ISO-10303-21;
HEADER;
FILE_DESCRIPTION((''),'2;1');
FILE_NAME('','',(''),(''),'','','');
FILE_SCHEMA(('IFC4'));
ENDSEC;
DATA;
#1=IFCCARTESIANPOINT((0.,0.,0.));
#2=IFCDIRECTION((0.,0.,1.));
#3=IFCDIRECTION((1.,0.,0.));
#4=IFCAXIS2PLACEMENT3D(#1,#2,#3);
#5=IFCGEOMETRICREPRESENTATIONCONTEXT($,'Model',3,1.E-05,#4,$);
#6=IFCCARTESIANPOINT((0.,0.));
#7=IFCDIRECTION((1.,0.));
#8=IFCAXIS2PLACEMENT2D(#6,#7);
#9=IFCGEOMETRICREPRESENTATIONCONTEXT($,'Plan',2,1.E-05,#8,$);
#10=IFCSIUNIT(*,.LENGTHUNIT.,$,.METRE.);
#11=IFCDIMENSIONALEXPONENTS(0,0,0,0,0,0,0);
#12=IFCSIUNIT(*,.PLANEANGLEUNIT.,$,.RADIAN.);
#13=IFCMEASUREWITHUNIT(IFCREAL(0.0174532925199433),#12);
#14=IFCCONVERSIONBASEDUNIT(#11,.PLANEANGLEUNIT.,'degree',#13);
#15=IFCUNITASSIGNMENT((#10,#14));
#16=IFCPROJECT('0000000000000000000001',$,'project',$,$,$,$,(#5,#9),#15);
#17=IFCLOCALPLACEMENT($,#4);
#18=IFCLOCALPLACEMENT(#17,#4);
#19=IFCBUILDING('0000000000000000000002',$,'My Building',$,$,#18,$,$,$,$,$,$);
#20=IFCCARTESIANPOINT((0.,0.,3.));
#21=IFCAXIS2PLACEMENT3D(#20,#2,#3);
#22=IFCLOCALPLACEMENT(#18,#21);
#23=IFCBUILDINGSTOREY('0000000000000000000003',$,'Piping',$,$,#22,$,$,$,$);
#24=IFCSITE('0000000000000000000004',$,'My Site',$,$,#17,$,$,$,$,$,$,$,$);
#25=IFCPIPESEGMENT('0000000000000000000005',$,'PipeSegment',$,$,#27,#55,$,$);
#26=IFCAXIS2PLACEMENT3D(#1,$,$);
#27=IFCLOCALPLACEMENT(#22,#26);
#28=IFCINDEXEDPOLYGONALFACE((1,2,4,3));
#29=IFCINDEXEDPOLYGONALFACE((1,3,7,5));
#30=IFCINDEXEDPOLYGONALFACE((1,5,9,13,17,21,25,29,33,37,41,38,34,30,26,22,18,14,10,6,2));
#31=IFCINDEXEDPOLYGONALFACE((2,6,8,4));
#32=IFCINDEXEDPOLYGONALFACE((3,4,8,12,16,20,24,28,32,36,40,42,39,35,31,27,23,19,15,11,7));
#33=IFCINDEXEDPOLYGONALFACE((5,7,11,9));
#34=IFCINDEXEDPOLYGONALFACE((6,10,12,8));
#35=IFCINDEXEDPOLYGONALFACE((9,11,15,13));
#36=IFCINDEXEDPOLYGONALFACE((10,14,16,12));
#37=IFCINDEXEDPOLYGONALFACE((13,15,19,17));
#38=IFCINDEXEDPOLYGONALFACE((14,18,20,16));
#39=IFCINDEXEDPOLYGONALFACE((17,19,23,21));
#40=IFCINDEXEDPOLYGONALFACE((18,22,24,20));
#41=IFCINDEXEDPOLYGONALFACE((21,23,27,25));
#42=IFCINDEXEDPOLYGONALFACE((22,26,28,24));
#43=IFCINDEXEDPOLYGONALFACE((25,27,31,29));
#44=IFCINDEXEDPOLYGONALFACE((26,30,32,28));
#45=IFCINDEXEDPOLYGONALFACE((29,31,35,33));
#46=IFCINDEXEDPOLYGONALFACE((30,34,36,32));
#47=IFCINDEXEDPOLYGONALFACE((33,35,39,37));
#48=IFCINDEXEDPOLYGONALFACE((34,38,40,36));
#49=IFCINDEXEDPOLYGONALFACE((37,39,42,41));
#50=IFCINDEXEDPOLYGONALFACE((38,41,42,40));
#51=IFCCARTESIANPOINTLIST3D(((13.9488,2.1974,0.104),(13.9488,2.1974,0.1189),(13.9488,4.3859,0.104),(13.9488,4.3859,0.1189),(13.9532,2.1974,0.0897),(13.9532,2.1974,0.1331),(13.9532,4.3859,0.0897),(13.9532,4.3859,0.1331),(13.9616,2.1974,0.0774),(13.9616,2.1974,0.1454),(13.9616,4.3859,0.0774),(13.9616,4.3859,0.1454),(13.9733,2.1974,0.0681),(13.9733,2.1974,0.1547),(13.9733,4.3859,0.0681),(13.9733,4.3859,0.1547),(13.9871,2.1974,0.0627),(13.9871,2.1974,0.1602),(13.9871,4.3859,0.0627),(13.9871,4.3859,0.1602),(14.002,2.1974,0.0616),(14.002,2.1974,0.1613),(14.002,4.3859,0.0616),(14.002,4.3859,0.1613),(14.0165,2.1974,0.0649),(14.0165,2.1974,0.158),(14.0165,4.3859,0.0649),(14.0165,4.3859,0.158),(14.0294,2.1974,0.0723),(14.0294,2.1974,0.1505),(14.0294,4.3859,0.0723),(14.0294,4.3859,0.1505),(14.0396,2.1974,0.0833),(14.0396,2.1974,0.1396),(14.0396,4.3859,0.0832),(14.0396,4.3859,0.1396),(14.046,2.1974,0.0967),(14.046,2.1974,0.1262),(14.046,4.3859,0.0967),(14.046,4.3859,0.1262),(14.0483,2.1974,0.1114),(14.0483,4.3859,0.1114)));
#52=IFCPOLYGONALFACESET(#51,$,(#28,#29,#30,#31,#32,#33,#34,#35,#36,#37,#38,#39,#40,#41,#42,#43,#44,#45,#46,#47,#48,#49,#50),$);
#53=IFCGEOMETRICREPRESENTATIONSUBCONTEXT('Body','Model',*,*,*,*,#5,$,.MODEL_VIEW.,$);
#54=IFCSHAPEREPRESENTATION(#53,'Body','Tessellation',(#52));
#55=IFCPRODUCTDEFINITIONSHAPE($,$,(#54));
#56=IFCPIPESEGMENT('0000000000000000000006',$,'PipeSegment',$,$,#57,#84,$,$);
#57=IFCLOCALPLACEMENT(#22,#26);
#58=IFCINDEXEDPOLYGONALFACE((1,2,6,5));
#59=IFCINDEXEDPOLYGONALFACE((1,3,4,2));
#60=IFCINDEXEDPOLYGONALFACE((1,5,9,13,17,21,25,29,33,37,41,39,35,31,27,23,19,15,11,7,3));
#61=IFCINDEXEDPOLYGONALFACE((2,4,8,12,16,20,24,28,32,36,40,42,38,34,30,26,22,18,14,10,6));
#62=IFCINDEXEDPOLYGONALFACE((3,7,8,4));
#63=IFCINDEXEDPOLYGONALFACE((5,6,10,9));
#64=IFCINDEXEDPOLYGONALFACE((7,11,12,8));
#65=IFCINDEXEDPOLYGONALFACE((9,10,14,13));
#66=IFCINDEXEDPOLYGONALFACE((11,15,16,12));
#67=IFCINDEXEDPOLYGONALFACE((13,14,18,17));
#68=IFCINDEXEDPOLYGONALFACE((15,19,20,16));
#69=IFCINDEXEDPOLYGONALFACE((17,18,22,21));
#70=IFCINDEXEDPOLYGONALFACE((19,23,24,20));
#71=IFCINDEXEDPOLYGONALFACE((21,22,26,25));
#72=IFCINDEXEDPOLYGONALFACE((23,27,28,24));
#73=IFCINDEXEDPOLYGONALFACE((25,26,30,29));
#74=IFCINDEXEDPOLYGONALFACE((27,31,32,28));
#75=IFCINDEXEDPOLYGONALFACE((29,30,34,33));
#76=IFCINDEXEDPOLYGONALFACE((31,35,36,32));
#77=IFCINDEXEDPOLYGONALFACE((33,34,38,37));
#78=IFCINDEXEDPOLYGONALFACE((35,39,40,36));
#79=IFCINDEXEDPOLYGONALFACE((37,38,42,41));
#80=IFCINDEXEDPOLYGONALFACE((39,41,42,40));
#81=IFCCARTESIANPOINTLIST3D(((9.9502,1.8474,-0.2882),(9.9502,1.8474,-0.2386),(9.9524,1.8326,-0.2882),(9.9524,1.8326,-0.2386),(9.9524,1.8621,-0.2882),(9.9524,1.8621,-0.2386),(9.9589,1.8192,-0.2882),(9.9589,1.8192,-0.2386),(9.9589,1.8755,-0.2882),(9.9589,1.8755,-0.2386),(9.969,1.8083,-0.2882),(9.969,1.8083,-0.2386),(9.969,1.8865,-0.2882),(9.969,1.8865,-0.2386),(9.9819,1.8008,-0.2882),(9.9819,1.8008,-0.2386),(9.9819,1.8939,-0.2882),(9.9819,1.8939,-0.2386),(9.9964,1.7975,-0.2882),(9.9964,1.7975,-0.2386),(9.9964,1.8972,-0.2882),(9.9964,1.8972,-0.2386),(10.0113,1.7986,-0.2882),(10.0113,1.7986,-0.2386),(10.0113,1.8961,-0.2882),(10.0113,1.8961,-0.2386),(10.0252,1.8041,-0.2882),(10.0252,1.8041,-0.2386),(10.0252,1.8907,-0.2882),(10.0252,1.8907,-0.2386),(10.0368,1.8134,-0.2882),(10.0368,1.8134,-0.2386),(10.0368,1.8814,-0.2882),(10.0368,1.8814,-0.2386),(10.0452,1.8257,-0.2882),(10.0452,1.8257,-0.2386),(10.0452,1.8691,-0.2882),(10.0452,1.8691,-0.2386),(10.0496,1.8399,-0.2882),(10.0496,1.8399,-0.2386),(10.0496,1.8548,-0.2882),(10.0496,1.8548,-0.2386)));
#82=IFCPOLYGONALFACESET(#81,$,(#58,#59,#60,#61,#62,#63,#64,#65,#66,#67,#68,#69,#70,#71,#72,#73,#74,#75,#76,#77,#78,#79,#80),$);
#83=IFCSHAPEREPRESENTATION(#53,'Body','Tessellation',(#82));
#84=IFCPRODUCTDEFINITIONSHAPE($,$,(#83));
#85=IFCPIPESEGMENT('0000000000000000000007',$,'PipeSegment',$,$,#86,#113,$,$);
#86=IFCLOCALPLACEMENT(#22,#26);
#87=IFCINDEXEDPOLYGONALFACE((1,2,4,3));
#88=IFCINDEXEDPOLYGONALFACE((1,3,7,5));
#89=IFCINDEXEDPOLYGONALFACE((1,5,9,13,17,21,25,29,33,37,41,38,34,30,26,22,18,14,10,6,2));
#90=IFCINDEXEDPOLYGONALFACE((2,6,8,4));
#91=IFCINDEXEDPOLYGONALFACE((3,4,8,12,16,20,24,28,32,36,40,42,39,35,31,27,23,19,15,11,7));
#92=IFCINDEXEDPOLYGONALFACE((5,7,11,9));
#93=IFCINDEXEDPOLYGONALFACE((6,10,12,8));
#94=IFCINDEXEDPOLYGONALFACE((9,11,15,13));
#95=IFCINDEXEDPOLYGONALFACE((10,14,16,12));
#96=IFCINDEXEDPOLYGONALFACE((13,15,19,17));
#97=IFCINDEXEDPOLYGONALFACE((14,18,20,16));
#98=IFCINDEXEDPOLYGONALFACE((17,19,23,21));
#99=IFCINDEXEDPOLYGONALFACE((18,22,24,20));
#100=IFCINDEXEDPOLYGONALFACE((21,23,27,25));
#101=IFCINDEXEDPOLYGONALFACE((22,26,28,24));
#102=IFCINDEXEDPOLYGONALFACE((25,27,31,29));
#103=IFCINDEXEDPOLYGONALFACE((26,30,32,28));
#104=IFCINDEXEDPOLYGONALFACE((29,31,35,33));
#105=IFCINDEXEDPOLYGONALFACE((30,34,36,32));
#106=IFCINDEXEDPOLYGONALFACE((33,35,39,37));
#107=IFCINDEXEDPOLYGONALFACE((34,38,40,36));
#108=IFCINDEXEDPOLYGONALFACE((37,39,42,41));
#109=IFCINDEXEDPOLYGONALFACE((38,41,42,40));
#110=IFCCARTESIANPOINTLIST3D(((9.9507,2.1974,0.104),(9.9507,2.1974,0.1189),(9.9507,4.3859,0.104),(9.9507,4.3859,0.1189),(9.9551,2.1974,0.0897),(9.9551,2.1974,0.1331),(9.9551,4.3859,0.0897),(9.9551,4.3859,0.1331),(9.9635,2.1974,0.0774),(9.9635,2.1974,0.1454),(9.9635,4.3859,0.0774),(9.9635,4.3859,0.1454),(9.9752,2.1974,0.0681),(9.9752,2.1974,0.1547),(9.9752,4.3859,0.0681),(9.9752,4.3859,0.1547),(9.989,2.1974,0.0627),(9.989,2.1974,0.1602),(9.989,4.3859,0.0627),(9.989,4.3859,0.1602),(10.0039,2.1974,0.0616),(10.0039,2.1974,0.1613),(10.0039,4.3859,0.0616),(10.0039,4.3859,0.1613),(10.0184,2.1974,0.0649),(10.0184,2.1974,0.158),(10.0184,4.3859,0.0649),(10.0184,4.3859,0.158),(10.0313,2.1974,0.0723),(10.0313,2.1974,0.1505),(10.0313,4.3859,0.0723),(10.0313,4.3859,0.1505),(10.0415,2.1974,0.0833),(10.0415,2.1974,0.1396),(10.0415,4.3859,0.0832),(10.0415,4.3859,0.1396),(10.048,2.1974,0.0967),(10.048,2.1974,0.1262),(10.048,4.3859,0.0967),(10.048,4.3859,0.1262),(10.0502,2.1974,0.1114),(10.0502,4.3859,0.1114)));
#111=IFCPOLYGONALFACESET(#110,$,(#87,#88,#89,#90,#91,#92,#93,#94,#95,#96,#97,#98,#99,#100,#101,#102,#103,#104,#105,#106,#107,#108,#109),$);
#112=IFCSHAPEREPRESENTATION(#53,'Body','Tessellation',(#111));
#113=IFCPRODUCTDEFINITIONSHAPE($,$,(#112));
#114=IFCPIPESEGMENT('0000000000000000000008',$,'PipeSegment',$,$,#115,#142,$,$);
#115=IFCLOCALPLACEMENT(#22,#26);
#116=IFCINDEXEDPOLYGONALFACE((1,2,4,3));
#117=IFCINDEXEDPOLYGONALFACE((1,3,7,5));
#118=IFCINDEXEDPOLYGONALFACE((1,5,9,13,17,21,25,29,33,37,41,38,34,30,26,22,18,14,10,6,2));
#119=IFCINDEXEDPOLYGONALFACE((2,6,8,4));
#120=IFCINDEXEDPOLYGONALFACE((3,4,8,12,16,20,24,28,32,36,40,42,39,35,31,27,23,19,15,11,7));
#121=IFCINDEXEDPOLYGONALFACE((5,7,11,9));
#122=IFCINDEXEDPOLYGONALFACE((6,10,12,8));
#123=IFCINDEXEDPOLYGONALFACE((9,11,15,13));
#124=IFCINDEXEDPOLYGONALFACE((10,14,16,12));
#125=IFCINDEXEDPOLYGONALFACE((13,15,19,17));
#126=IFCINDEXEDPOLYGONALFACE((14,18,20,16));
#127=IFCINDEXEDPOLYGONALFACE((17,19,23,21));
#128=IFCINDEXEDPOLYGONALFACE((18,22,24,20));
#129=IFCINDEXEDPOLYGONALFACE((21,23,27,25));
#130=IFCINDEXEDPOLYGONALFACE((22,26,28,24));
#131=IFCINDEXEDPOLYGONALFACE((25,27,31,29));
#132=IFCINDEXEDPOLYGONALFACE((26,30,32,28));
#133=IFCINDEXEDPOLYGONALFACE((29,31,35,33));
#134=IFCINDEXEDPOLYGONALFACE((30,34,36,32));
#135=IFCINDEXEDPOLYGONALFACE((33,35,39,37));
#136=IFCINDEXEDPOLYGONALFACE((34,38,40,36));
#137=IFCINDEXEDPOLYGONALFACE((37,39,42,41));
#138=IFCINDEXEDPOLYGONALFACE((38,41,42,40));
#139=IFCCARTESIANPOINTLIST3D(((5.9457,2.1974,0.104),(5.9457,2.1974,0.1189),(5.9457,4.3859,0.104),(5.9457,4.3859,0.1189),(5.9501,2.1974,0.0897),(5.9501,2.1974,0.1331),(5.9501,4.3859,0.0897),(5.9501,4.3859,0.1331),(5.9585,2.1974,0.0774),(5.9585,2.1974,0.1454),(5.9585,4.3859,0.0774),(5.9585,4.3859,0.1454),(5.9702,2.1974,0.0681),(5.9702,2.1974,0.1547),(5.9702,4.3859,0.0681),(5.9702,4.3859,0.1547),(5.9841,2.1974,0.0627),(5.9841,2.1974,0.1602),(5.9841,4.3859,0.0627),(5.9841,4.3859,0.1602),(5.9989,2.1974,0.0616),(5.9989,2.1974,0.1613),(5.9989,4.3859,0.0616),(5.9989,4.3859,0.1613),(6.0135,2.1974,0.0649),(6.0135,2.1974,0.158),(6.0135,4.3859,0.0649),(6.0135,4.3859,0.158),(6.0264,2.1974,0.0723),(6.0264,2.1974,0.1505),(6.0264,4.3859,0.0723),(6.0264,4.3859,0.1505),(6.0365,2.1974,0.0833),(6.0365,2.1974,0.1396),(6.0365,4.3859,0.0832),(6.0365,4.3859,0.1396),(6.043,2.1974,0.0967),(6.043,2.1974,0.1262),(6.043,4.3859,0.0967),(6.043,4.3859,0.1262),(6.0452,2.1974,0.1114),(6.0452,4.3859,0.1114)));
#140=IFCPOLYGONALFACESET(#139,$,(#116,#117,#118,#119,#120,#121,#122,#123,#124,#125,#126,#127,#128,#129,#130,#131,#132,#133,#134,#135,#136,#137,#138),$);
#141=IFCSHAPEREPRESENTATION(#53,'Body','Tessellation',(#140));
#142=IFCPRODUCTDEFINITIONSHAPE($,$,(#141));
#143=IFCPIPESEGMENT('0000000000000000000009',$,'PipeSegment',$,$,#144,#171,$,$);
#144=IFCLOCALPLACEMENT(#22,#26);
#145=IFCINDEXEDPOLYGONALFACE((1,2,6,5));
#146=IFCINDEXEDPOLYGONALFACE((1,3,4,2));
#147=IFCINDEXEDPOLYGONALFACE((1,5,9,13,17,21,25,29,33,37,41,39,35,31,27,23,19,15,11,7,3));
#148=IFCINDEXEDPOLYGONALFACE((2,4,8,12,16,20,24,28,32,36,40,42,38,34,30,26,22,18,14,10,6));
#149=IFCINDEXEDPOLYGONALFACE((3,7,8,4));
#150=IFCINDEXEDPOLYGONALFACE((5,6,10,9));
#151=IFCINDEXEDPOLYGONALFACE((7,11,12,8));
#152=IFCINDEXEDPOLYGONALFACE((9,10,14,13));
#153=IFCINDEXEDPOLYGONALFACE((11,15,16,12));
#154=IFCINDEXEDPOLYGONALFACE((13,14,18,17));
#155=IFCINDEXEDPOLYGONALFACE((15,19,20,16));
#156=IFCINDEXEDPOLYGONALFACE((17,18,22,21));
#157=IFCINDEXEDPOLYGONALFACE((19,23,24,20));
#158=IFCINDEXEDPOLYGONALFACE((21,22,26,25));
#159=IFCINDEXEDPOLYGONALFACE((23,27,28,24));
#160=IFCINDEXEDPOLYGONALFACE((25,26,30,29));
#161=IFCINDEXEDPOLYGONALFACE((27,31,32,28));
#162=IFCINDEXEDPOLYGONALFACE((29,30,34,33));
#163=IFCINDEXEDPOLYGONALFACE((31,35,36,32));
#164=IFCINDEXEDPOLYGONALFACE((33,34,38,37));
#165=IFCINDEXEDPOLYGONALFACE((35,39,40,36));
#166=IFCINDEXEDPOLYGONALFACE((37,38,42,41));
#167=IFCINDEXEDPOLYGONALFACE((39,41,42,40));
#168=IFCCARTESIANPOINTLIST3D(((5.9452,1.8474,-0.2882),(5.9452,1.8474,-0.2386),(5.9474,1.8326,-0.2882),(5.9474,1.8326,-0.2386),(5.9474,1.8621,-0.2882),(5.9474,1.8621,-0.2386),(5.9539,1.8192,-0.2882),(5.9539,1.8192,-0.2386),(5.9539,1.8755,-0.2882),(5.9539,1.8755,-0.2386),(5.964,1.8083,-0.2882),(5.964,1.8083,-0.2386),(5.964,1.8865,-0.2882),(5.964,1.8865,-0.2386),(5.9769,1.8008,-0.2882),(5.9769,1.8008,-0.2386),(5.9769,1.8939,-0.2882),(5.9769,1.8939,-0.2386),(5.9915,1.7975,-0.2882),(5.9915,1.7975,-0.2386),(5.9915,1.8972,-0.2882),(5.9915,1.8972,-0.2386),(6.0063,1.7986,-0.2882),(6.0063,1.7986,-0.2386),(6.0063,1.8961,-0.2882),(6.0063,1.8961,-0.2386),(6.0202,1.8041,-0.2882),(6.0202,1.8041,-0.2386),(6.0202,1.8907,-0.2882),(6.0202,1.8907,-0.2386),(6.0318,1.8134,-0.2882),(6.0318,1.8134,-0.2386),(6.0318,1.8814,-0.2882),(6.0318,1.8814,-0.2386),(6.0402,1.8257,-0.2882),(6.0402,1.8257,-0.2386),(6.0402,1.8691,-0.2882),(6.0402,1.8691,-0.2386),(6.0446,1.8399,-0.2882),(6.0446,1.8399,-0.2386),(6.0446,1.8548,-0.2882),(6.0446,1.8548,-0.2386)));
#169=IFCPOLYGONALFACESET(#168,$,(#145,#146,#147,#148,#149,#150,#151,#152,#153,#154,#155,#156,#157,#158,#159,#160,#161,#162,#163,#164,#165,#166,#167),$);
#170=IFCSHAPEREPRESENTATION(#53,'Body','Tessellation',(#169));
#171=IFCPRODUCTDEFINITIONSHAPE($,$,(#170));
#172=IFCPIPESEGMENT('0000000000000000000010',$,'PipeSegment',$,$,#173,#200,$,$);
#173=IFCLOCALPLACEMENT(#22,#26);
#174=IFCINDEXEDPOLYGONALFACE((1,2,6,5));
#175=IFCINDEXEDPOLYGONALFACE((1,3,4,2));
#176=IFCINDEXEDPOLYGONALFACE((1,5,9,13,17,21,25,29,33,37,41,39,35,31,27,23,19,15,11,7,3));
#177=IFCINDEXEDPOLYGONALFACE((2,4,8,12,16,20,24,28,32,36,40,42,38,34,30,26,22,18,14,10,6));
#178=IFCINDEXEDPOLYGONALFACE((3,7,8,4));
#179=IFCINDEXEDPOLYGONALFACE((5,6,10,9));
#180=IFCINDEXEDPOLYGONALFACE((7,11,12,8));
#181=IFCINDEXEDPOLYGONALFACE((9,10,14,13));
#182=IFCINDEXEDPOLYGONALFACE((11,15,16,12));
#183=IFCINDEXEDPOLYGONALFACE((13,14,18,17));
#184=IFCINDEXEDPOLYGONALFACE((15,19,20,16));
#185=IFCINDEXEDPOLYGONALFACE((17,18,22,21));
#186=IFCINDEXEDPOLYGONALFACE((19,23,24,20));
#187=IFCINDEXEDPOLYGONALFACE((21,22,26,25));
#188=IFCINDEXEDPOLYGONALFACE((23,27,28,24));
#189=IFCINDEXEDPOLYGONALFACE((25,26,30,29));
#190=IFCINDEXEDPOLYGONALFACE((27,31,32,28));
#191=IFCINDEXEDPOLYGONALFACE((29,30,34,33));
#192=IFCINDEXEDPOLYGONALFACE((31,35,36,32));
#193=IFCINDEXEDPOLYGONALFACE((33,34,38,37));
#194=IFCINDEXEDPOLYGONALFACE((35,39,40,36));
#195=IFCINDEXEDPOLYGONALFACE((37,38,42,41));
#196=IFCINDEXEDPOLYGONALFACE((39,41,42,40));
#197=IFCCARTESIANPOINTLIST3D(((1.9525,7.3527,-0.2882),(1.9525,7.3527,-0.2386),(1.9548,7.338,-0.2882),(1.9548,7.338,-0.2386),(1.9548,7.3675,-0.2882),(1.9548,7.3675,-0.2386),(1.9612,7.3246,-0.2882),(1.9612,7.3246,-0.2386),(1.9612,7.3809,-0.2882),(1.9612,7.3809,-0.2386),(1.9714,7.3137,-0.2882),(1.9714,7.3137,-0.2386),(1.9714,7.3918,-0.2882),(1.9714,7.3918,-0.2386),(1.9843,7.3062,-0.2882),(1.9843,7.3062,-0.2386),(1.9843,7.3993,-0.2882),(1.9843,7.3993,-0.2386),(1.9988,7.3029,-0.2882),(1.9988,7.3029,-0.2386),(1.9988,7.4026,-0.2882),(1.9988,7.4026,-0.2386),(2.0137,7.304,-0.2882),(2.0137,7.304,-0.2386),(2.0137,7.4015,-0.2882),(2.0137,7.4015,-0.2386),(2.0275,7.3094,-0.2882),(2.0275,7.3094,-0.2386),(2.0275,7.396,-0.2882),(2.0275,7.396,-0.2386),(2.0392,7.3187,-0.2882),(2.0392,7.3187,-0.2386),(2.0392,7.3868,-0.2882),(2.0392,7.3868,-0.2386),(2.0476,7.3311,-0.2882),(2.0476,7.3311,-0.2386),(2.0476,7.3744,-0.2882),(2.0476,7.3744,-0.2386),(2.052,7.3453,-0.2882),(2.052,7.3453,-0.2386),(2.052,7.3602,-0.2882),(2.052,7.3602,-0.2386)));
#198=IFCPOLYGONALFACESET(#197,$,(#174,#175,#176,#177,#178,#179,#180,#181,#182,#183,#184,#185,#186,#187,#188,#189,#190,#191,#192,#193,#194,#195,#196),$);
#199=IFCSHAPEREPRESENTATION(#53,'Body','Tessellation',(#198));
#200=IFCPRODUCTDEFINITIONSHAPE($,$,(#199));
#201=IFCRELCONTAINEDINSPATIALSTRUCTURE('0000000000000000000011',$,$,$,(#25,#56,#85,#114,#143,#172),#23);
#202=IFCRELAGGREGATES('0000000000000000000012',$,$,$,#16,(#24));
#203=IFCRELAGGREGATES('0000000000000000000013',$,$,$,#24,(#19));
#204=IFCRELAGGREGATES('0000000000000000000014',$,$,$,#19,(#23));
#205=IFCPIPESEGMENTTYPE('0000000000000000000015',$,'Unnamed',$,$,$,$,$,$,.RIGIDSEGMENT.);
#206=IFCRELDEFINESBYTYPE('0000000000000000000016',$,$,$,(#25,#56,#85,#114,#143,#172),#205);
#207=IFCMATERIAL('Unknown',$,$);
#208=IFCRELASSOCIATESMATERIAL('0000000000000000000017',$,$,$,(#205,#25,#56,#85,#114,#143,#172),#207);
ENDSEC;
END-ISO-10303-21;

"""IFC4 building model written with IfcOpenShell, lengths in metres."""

from ifc_helpers import new_model, entity, si_unit, converted_unit, frame, origin_with_axes, origin_2d_with_axis, place, context, subcontext, project, spatial, circle, extrude, material, material_profile, profile_set, profile_usage, type_object, element, save


model = new_model("IFC4")

# Units and contexts
model_context = context("Model", 3, precision=1e-05, world=origin_with_axes())
plan_context = context("Plan", 2, precision=1e-05, world=origin_2d_with_axis())
body_context = subcontext(model_context, "Body", "Model", "MODEL_VIEW")
ifc_project = project(units=[si_unit("LENGTHUNIT", "METRE"), converted_unit("PLANEANGLEUNIT", "degree", entity("IfcReal", 0.0174532925199433), si_unit("PLANEANGLEUNIT", "RADIAN"), dimensions=[0, 0, 0, 0, 0, 0, 0])], contexts=[model_context, plan_context])

# Site, building, storey
site_placement = place(None, origin_with_axes())
site = spatial("IfcSite", under=ifc_project, at=site_placement, Name="My Site")
building_placement = place(site_placement, origin_with_axes())
building = spatial("IfcBuilding", under=site, at=building_placement, Name="My Building")
storey_placement = place(building_placement, frame((0.0, 0.0, 3.0), z_axis=(0.0, 0.0, 1.0), x_axis=(1.0, 0.0, 0.0)))
storey = spatial("IfcBuildingStorey", under=building, at=storey_placement, Name="Piping")

# Pipe segments
ifc_material = material(Name="Unknown")
ifc_material_profile_1 = material_profile(ifc_material, circle(Radius=0.05))
ifc_profile_set_1 = profile_set([ifc_material_profile_1])
pipe_segment_type = type_object("IfcPipeSegmentType", Name="Unnamed", PredefinedType="RIGIDSEGMENT", material=ifc_profile_set_1)
ifc_profile_usage_1 = profile_usage(ifc_profile_set_1, cardinal=16)
pipe_segment_1_placement = place(storey_placement, frame((13.9983, 4.3859, 0.1114), z_axis=(0.0, -1.0, 0.0), x_axis=(1.0, 0.0, 0.0)))
element("IfcPipeSegment", 1, at=pipe_segment_1_placement, inside=storey, type_object=pipe_segment_type, material=ifc_profile_usage_1, Name="PipeSegment", context=body_context, shape_type="SweptSolid", body=[
    extrude(circle(Radius=0.05), origin_with_axes(), (0.0, 0.0, 1.0), 2.1885),
])
ifc_profile_usage_2 = profile_usage(ifc_profile_set_1, cardinal=16)
pipe_segment_2_placement = place(storey_placement, frame((10.0002, 1.8474, -0.2386), z_axis=(0.0, 0.0, -1.0), x_axis=(-1.0, 0.0, 0.0)))
element("IfcPipeSegment", 2, at=pipe_segment_2_placement, inside=storey, type_object=pipe_segment_type, material=ifc_profile_usage_2, Name="PipeSegment", context=body_context, shape_type="SweptSolid", body=[
    extrude(circle(Radius=0.05), origin_with_axes(), (0.0, 0.0, 1.0), 0.0496),
])
ifc_profile_usage_3 = profile_usage(ifc_profile_set_1, cardinal=16)
pipe_segment_3_placement = place(storey_placement, frame((10.0002, 4.3859, 0.1114), z_axis=(0.0, -1.0, 0.0), x_axis=(1.0, 0.0, 0.0)))
element("IfcPipeSegment", 3, at=pipe_segment_3_placement, inside=storey, type_object=pipe_segment_type, material=ifc_profile_usage_3, Name="PipeSegment", context=body_context, shape_type="SweptSolid", body=[
    extrude(circle(Radius=0.05), origin_with_axes(), (0.0, 0.0, 1.0), 2.1885),
])
ifc_profile_usage_4 = profile_usage(ifc_profile_set_1, cardinal=16)
pipe_segment_4_placement = place(storey_placement, frame((5.9952, 4.3859, 0.1114), z_axis=(0.0, -1.0, 0.0), x_axis=(1.0, 0.0, 0.0)))
element("IfcPipeSegment", 4, at=pipe_segment_4_placement, inside=storey, type_object=pipe_segment_type, material=ifc_profile_usage_4, Name="PipeSegment", context=body_context, shape_type="SweptSolid", body=[
    extrude(circle(Radius=0.05), origin_with_axes(), (0.0, 0.0, 1.0), 2.1885),
])
ifc_profile_usage_5 = profile_usage(ifc_profile_set_1, cardinal=16)
pipe_segment_5_placement = place(storey_placement, frame((5.9952, 1.8474, -0.2386), z_axis=(0.0, 0.0, -1.0), x_axis=(-1.0, 0.0, 0.0)))
element("IfcPipeSegment", 5, at=pipe_segment_5_placement, inside=storey, type_object=pipe_segment_type, material=ifc_profile_usage_5, Name="PipeSegment", context=body_context, shape_type="SweptSolid", body=[
    extrude(circle(Radius=0.05), origin_with_axes(), (0.0, 0.0, 1.0), 0.0496),
])
ifc_profile_usage_6 = profile_usage(ifc_profile_set_1, cardinal=16)
pipe_segment_6_placement = place(storey_placement, frame((2.0025, 7.3527, -0.2386), z_axis=(0.0, 0.0, -1.0), x_axis=(-1.0, 0.0, 0.0)))
element("IfcPipeSegment", 6, at=pipe_segment_6_placement, inside=storey, type_object=pipe_segment_type, material=ifc_profile_usage_6, Name="PipeSegment", context=body_context, shape_type="SweptSolid", body=[
    extrude(circle(Radius=0.05), origin_with_axes(), (0.0, 0.0, 1.0), 0.0496),
])

save(model, "model.ifc")
